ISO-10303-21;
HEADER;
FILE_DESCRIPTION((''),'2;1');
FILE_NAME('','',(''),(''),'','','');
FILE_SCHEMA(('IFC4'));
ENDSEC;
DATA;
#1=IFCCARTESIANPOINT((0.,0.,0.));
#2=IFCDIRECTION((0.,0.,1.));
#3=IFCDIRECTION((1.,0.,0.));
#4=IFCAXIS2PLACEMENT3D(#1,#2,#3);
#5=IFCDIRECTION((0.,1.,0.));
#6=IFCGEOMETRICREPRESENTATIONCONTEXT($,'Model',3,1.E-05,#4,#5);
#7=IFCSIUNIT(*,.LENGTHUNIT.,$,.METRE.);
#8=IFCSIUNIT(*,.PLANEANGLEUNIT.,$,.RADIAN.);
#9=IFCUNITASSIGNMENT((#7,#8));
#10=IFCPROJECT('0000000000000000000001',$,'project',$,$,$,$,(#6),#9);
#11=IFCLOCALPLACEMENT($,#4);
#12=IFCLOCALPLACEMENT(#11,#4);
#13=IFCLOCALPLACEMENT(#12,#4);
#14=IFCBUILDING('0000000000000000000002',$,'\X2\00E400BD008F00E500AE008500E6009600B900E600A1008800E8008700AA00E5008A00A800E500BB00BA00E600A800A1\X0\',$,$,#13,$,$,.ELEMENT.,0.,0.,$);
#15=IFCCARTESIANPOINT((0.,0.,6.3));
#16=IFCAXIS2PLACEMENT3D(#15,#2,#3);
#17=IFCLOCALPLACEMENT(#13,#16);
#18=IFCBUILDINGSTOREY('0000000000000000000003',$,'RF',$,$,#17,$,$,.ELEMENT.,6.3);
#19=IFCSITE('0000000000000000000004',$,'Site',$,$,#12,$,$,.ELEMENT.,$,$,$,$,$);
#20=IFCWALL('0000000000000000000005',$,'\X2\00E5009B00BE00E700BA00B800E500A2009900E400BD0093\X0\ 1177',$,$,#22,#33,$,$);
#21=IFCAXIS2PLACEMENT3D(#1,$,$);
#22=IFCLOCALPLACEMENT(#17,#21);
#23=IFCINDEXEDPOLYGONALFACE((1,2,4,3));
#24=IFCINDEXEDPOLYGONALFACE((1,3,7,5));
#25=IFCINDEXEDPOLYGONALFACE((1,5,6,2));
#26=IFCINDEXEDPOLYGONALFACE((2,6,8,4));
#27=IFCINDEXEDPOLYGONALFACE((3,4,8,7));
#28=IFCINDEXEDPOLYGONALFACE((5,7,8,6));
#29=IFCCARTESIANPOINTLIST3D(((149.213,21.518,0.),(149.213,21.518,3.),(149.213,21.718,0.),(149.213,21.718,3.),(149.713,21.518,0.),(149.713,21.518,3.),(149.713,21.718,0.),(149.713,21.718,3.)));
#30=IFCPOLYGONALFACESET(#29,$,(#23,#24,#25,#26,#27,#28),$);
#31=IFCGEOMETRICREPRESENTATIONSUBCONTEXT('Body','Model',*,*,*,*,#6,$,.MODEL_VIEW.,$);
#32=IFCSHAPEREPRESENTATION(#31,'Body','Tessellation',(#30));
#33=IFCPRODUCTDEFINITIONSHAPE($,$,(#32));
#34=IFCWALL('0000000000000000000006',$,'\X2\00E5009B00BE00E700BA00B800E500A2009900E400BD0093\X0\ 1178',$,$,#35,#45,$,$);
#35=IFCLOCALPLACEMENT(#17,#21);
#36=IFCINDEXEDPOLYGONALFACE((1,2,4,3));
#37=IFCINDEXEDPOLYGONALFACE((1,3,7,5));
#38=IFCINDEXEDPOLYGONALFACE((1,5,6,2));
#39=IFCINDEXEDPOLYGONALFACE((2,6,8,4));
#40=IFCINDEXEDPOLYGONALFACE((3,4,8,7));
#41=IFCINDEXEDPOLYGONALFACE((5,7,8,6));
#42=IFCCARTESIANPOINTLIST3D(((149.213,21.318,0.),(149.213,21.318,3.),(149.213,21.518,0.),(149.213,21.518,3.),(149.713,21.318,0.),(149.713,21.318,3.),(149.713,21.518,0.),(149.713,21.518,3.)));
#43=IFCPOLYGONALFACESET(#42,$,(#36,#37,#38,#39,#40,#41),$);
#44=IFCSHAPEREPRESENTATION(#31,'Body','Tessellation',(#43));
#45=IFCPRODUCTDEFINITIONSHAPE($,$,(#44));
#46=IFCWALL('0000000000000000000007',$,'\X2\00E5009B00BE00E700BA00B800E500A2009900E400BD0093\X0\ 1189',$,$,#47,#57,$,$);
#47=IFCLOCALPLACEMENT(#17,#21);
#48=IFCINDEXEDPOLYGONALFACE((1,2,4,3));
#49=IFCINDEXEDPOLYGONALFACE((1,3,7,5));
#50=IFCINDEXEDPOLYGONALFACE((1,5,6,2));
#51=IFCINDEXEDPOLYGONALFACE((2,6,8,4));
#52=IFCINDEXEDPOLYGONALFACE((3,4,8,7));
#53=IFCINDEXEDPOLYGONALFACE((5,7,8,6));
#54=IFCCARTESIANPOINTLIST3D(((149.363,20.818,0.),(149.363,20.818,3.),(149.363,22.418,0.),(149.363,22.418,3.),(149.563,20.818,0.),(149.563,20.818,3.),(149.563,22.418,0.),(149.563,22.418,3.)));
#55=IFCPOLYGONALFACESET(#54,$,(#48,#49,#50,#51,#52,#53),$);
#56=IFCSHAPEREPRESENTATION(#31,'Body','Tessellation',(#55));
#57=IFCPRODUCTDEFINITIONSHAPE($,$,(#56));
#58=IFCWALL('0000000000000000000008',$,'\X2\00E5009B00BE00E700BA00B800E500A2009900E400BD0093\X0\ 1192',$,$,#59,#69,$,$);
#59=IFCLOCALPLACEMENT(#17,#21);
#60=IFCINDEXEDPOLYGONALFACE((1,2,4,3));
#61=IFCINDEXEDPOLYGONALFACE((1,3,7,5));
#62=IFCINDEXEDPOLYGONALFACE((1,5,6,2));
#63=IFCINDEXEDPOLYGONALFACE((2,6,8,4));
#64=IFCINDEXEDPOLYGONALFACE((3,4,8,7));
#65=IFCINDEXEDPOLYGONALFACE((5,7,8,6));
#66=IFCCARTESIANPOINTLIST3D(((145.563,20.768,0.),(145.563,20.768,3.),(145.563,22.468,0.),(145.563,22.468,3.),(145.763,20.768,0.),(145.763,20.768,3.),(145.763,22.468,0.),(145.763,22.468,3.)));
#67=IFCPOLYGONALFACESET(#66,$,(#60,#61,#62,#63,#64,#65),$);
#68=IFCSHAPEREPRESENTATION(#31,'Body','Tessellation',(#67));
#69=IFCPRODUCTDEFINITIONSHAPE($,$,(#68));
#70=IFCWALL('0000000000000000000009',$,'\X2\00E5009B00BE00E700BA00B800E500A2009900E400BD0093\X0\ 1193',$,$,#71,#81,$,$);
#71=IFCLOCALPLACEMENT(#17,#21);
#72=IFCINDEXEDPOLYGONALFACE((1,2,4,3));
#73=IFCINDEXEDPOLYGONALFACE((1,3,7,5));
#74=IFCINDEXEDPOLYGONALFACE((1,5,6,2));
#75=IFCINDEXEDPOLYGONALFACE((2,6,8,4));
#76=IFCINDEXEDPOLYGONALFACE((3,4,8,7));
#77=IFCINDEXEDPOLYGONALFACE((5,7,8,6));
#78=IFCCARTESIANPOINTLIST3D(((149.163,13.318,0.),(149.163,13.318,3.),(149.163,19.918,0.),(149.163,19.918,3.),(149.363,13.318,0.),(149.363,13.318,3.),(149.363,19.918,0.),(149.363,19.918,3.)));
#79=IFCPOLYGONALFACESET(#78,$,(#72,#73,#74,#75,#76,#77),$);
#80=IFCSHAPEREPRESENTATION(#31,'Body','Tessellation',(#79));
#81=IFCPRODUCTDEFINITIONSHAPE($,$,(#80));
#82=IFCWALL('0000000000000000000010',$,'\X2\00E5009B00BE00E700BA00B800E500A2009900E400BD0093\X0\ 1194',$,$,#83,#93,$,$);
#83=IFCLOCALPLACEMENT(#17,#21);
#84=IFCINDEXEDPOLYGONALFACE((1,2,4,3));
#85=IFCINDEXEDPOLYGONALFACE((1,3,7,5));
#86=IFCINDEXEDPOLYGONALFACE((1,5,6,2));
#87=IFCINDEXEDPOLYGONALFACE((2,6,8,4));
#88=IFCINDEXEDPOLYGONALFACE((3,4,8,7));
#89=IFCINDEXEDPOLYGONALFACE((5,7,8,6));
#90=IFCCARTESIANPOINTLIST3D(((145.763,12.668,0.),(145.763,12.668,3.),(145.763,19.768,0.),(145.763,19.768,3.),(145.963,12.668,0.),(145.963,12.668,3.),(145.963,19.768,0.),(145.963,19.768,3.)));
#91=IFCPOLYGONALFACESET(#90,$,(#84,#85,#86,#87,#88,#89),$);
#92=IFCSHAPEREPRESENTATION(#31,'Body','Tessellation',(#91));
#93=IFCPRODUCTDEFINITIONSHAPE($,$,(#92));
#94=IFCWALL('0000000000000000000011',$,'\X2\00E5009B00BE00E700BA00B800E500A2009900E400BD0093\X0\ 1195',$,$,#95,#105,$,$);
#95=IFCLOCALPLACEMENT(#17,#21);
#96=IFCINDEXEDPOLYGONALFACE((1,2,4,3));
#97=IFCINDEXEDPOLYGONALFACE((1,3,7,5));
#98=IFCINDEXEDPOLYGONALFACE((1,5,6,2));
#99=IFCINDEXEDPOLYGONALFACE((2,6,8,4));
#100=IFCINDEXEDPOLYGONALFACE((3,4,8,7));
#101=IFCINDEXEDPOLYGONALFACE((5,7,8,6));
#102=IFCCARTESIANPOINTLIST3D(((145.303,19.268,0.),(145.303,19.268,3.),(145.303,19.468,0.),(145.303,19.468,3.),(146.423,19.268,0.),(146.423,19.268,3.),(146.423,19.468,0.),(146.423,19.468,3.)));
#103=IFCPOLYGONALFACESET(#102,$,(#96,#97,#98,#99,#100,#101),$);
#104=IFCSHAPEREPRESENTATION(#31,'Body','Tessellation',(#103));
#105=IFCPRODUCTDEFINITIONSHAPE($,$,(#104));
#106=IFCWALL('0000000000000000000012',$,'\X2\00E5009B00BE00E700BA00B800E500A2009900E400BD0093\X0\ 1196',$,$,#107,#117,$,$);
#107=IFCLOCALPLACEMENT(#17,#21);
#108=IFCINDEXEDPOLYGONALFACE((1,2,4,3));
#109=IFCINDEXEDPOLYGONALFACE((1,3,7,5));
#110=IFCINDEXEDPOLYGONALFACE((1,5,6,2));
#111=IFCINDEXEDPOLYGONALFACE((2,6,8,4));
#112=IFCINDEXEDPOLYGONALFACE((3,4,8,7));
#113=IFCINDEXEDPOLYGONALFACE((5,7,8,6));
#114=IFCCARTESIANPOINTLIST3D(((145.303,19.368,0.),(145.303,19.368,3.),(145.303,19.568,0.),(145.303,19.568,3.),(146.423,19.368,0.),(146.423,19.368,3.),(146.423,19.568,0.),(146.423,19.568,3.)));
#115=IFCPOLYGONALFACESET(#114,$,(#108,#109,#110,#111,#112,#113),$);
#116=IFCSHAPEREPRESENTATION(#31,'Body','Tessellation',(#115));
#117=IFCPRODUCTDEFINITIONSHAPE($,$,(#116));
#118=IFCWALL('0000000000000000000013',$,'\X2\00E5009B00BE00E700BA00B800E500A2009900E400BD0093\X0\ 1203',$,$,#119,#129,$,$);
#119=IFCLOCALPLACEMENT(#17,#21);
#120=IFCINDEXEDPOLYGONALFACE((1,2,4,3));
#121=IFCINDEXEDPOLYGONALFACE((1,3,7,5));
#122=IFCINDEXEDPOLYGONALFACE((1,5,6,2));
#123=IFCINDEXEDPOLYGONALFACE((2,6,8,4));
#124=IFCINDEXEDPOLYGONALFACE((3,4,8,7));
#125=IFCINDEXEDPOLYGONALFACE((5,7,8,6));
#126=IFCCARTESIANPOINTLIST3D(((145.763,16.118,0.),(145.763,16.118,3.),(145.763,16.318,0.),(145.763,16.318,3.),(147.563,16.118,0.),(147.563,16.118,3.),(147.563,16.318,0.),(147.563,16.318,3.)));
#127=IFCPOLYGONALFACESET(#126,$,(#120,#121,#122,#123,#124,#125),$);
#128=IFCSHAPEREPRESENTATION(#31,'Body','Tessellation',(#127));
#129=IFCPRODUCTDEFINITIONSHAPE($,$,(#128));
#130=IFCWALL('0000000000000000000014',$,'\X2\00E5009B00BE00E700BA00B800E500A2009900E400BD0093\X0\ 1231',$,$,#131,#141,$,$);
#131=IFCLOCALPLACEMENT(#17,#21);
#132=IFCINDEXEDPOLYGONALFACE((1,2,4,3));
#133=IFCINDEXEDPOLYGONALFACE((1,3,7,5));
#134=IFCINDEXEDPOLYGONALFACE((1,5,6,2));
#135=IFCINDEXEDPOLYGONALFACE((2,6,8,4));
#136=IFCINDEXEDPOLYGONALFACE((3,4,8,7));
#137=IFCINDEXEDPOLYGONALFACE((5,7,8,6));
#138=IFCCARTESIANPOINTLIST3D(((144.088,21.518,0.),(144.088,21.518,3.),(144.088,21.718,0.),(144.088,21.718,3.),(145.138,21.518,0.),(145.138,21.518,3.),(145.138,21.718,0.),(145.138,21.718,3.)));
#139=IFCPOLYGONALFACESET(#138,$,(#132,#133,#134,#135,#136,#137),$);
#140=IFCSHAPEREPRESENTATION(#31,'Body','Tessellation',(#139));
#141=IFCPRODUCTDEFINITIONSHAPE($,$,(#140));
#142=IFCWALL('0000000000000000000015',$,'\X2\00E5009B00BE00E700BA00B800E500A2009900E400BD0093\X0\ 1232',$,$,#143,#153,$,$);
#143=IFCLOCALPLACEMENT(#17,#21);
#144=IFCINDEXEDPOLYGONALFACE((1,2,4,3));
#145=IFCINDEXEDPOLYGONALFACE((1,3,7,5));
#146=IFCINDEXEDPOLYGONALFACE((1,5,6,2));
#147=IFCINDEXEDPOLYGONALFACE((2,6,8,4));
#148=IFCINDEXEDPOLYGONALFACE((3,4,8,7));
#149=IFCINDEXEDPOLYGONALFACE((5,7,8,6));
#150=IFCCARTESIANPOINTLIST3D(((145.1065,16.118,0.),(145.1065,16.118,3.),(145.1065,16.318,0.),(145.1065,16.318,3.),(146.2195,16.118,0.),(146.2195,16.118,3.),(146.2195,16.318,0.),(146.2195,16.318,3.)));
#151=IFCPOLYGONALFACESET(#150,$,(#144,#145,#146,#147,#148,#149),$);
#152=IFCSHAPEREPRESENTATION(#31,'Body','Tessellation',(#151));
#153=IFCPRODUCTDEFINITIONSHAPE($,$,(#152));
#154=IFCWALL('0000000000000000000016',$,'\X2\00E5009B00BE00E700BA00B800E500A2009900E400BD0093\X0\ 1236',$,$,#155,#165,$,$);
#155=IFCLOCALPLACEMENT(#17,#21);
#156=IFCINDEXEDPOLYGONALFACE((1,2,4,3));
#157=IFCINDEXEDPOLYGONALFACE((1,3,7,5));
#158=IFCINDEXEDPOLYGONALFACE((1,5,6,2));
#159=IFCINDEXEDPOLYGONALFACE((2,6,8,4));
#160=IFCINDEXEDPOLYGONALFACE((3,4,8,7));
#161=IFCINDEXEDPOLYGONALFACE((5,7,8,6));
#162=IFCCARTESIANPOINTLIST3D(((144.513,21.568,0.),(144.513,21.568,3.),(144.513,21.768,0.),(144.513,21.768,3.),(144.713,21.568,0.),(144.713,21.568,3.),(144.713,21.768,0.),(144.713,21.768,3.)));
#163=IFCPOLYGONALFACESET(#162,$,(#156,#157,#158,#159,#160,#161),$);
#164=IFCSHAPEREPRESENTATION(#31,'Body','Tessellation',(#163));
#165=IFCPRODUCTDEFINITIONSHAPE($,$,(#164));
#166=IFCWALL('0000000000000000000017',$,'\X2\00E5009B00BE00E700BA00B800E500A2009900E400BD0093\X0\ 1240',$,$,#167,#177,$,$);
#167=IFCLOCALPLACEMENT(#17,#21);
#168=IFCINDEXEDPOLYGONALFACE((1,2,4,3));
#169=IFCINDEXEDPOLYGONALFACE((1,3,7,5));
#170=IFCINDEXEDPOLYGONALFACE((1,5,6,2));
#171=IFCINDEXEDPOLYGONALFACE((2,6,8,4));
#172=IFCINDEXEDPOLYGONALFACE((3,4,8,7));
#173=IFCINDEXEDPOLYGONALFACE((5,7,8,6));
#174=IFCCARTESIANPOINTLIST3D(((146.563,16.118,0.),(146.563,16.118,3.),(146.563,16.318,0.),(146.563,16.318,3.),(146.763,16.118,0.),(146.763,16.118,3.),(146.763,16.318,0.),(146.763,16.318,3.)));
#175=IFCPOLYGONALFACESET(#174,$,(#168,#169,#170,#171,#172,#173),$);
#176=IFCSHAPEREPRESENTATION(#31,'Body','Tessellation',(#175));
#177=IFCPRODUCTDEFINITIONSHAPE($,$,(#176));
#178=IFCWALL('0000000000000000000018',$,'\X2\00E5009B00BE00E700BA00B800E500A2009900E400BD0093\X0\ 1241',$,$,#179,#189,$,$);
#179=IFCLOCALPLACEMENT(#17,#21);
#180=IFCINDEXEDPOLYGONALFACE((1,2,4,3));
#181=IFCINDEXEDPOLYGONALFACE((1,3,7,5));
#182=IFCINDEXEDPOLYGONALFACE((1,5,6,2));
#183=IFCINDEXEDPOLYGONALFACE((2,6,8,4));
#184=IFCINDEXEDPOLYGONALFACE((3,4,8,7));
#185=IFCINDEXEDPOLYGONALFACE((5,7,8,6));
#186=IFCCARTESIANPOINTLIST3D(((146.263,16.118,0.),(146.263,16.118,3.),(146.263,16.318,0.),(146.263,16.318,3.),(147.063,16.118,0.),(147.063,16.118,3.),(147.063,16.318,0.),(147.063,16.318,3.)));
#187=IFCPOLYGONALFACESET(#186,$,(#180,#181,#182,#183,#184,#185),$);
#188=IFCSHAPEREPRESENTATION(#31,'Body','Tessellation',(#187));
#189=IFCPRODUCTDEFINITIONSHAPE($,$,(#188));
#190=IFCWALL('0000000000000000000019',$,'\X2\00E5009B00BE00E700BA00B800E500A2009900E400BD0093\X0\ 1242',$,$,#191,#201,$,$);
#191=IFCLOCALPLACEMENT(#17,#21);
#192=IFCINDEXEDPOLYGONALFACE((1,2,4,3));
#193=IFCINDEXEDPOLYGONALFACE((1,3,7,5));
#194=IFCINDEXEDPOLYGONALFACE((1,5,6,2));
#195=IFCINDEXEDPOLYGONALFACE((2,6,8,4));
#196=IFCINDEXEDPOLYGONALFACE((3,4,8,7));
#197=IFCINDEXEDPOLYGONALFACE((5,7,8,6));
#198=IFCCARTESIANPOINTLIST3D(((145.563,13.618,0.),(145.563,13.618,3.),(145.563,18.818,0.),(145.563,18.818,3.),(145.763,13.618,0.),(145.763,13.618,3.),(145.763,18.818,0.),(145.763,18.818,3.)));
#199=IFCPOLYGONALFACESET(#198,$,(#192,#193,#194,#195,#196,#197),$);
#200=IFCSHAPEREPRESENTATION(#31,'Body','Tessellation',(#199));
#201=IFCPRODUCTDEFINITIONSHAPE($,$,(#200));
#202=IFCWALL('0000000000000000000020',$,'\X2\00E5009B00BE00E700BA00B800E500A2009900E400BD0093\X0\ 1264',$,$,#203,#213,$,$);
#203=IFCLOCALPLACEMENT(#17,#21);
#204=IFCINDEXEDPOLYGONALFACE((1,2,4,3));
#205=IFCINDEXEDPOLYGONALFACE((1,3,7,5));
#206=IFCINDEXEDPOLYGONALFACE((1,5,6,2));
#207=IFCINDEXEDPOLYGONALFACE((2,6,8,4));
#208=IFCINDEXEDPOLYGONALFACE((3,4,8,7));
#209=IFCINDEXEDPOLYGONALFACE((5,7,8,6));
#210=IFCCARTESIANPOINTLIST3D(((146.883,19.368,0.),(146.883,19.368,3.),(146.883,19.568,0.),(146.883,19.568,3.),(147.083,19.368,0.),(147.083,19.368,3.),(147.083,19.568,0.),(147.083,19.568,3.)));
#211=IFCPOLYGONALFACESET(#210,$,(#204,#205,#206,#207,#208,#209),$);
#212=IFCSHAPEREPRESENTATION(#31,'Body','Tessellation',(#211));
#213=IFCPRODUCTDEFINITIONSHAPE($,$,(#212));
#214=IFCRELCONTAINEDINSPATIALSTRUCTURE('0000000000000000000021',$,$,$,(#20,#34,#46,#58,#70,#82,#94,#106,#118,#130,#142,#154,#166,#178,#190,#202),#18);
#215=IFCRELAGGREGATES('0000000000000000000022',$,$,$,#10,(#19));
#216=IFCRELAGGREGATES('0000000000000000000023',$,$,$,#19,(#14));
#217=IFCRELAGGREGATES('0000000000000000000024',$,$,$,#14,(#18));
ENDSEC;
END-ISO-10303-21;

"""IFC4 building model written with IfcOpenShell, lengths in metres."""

from ifc_helpers import new_model, si_unit, direction, frame, frame_2d, origin_with_axes, place, context, subcontext, project, spatial, rectangle, extrude, element, save


model = new_model("IFC4")

# Units and contexts
model_context = context("Model", 3, precision=1e-05, world=origin_with_axes(), true_north=direction((0.0, 1.0, 0.0)))
body_context = subcontext(model_context, "Body", "Model", "MODEL_VIEW")
ifc_project = project(units=[si_unit("LENGTHUNIT", "METRE"), si_unit("PLANEANGLEUNIT", "RADIAN")], contexts=[model_context])

# Site, building, storey
placement = place(None, origin_with_axes())
site_placement = place(placement, origin_with_axes())
site = spatial("IfcSite", under=ifc_project, at=site_placement, Name="Site", CompositionType="ELEMENT")
building_placement = place(site_placement, origin_with_axes())
building = spatial("IfcBuilding", under=site, at=building_placement, Name="ä½\u008få®\u0085æ\u0096¹æ¡\u0088è\u0087ªå\u008a¨å»ºæ¨¡", CompositionType="ELEMENT", ElevationOfRefHeight=0.0, ElevationOfTerrain=0.0)
storey_placement = place(building_placement, frame((0.0, 0.0, 6.3), z_axis=(0.0, 0.0, 1.0), x_axis=(1.0, 0.0, 0.0)))
storey = spatial("IfcBuildingStorey", under=building, at=storey_placement, Name="RF", CompositionType="ELEMENT", Elevation=6.3)

# Walls
for number, where, z_axis, x_axis, name in (
    (1, (149.463, 21.618, 0.0), (0.0, 0.0, 1.0), (1.0, 0.0, 0.0), "å\u009b¾çº¸å¢\u0099ä½\u0093 1177"),
    (2, (149.463, 21.418, 0.0), (0.0, 0.0, 1.0), (1.0, 0.0, 0.0), "å\u009b¾çº¸å¢\u0099ä½\u0093 1178"),
):
    element("IfcWall", number, at=place(storey_placement, frame(where, z_axis=z_axis, x_axis=x_axis)), inside=storey, Name=name, context=body_context, shape_type="SweptSolid", body=[
        extrude(rectangle(XDim=0.5, YDim=0.2, at=frame_2d((0.0, 0.0), x_axis=(1.0, 0.0, 0.0))), frame((0.0, 0.0, 0.0), z_axis=(0.0, 0.0, 1.0)), (0.0, 0.0, 1.0), 3.0),
    ])
wall_1_placement = place(storey_placement, frame((149.463, 21.618, 0.0), z_axis=(0.0, 0.0, 1.0), x_axis=(0.0, 1.0, 0.0)))
element("IfcWall", 3, at=wall_1_placement, inside=storey, Name="å\u009b¾çº¸å¢\u0099ä½\u0093 1189", context=body_context, shape_type="SweptSolid", body=[
    extrude(rectangle(XDim=1.6, YDim=0.2, at=frame_2d((0.0, 0.0), x_axis=(1.0, 0.0, 0.0))), frame((0.0, 0.0, 0.0), z_axis=(0.0, 0.0, 1.0)), (0.0, 0.0, 1.0), 3.0),
])
wall_2_placement = place(storey_placement, frame((145.663, 21.618, 0.0), z_axis=(0.0, 0.0, 1.0), x_axis=(0.0, 1.0, 0.0)))
element("IfcWall", 4, at=wall_2_placement, inside=storey, Name="å\u009b¾çº¸å¢\u0099ä½\u0093 1192", context=body_context, shape_type="SweptSolid", body=[
    extrude(rectangle(XDim=1.7, YDim=0.2, at=frame_2d((0.0, 0.0), x_axis=(1.0, 0.0, 0.0))), frame((0.0, 0.0, 0.0), z_axis=(0.0, 0.0, 1.0)), (0.0, 0.0, 1.0), 3.0),
])
wall_3_placement = place(storey_placement, frame((149.263, 16.618, 0.0), z_axis=(0.0, 0.0, 1.0), x_axis=(0.0, 1.0, 0.0)))
element("IfcWall", 5, at=wall_3_placement, inside=storey, Name="å\u009b¾çº¸å¢\u0099ä½\u0093 1193", context=body_context, shape_type="SweptSolid", body=[
    extrude(rectangle(XDim=6.6, YDim=0.2, at=frame_2d((0.0, 0.0), x_axis=(1.0, 0.0, 0.0))), frame((0.0, 0.0, 0.0), z_axis=(0.0, 0.0, 1.0)), (0.0, 0.0, 1.0), 3.0),
])
wall_4_placement = place(storey_placement, frame((145.863, 16.218, 0.0), z_axis=(0.0, 0.0, 1.0), x_axis=(0.0, 1.0, 0.0)))
element("IfcWall", 6, at=wall_4_placement, inside=storey, Name="å\u009b¾çº¸å¢\u0099ä½\u0093 1194", context=body_context, shape_type="SweptSolid", body=[
    extrude(rectangle(XDim=7.1, YDim=0.2, at=frame_2d((0.0, 0.0), x_axis=(1.0, 0.0, 0.0))), frame((0.0, 0.0, 0.0), z_axis=(0.0, 0.0, 1.0)), (0.0, 0.0, 1.0), 3.0),
])
for number, where, z_axis, x_axis, name in (
    (7, (145.863, 19.368, 0.0), (0.0, 0.0, 1.0), (1.0, 0.0, 0.0), "å\u009b¾çº¸å¢\u0099ä½\u0093 1195"),
    (8, (145.863, 19.468, 0.0), (0.0, 0.0, 1.0), (1.0, 0.0, 0.0), "å\u009b¾çº¸å¢\u0099ä½\u0093 1196"),
):
    element("IfcWall", number, at=place(storey_placement, frame(where, z_axis=z_axis, x_axis=x_axis)), inside=storey, Name=name, context=body_context, shape_type="SweptSolid", body=[
        extrude(rectangle(XDim=1.12, YDim=0.2, at=frame_2d((0.0, 0.0), x_axis=(1.0, 0.0, 0.0))), frame((0.0, 0.0, 0.0), z_axis=(0.0, 0.0, 1.0)), (0.0, 0.0, 1.0), 3.0),
    ])
wall_5_placement = place(storey_placement, frame((146.663, 16.218, 0.0), z_axis=(0.0, 0.0, 1.0), x_axis=(1.0, 0.0, 0.0)))
element("IfcWall", 9, at=wall_5_placement, inside=storey, Name="å\u009b¾çº¸å¢\u0099ä½\u0093 1203", context=body_context, shape_type="SweptSolid", body=[
    extrude(rectangle(XDim=1.8, YDim=0.2, at=frame_2d((0.0, 0.0), x_axis=(1.0, 0.0, 0.0))), frame((0.0, 0.0, 0.0), z_axis=(0.0, 0.0, 1.0)), (0.0, 0.0, 1.0), 3.0),
])
wall_6_placement = place(storey_placement, frame((144.613, 21.618, 0.0), z_axis=(0.0, 0.0, 1.0), x_axis=(1.0, 0.0, 0.0)))
element("IfcWall", 10, at=wall_6_placement, inside=storey, Name="å\u009b¾çº¸å¢\u0099ä½\u0093 1231", context=body_context, shape_type="SweptSolid", body=[
    extrude(rectangle(XDim=1.05, YDim=0.2, at=frame_2d((0.0, 0.0), x_axis=(1.0, 0.0, 0.0))), frame((0.0, 0.0, 0.0), z_axis=(0.0, 0.0, 1.0)), (0.0, 0.0, 1.0), 3.0),
])
wall_7_placement = place(storey_placement, frame((145.663, 16.218, 0.0), z_axis=(0.0, 0.0, 1.0), x_axis=(-1.0, 0.0, 0.0)))
element("IfcWall", 11, at=wall_7_placement, inside=storey, Name="å\u009b¾çº¸å¢\u0099ä½\u0093 1232", context=body_context, shape_type="SweptSolid", body=[
    extrude(rectangle(XDim=1.113, YDim=0.2, at=frame_2d((0.0, 0.0), x_axis=(1.0, 0.0, 0.0))), frame((0.0, 0.0, 0.0), z_axis=(0.0, 0.0, 1.0)), (0.0, 0.0, 1.0), 3.0),
])
for number, where, z_axis, x_axis, name in (
    (12, (144.613, 21.668, 0.0), (0.0, 0.0, 1.0), (-1.0, 0.0, 0.0), "å\u009b¾çº¸å¢\u0099ä½\u0093 1236"),
    (13, (146.663, 16.218, 0.0), (0.0, 0.0, 1.0), (0.0, -1.0, 0.0), "å\u009b¾çº¸å¢\u0099ä½\u0093 1240"),
):
    element("IfcWall", number, at=place(storey_placement, frame(where, z_axis=z_axis, x_axis=x_axis)), inside=storey, Name=name, context=body_context, shape_type="SweptSolid", body=[
        extrude(rectangle(XDim=0.2, YDim=0.2, at=frame_2d((0.0, 0.0), x_axis=(1.0, 0.0, 0.0))), frame((0.0, 0.0, 0.0), z_axis=(0.0, 0.0, 1.0)), (0.0, 0.0, 1.0), 3.0),
    ])
wall_8_placement = place(storey_placement, frame((146.663, 16.218, 0.0), z_axis=(0.0, 0.0, 1.0), x_axis=(-1.0, 0.0, 0.0)))
element("IfcWall", 14, at=wall_8_placement, inside=storey, Name="å\u009b¾çº¸å¢\u0099ä½\u0093 1241", context=body_context, shape_type="SweptSolid", body=[
    extrude(rectangle(XDim=0.8, YDim=0.2, at=frame_2d((0.0, 0.0), x_axis=(1.0, 0.0, 0.0))), frame((0.0, 0.0, 0.0), z_axis=(0.0, 0.0, 1.0)), (0.0, 0.0, 1.0), 3.0),
])
wall_9_placement = place(storey_placement, frame((145.663, 16.218, 0.0), z_axis=(0.0, 0.0, 1.0), x_axis=(0.0, 1.0, 0.0)))
element("IfcWall", 15, at=wall_9_placement, inside=storey, Name="å\u009b¾çº¸å¢\u0099ä½\u0093 1242", context=body_context, shape_type="SweptSolid", body=[
    extrude(rectangle(XDim=5.2, YDim=0.2, at=frame_2d((0.0, 0.0), x_axis=(1.0, 0.0, 0.0))), frame((0.0, 0.0, 0.0), z_axis=(0.0, 0.0, 1.0)), (0.0, 0.0, 1.0), 3.0),
])
for number, where, z_axis, x_axis, name in (
    (16, (146.983, 19.468, 0.0), (0.0, 0.0, 1.0), (0.0, -1.0, 0.0), "å\u009b¾çº¸å¢\u0099ä½\u0093 1264"),
):
    element("IfcWall", number, at=place(storey_placement, frame(where, z_axis=z_axis, x_axis=x_axis)), inside=storey, Name=name, context=body_context, shape_type="SweptSolid", body=[
        extrude(rectangle(XDim=0.2, YDim=0.2, at=frame_2d((0.0, 0.0), x_axis=(1.0, 0.0, 0.0))), frame((0.0, 0.0, 0.0), z_axis=(0.0, 0.0, 1.0)), (0.0, 0.0, 1.0), 3.0),
    ])

save(model, "model.ifc")
